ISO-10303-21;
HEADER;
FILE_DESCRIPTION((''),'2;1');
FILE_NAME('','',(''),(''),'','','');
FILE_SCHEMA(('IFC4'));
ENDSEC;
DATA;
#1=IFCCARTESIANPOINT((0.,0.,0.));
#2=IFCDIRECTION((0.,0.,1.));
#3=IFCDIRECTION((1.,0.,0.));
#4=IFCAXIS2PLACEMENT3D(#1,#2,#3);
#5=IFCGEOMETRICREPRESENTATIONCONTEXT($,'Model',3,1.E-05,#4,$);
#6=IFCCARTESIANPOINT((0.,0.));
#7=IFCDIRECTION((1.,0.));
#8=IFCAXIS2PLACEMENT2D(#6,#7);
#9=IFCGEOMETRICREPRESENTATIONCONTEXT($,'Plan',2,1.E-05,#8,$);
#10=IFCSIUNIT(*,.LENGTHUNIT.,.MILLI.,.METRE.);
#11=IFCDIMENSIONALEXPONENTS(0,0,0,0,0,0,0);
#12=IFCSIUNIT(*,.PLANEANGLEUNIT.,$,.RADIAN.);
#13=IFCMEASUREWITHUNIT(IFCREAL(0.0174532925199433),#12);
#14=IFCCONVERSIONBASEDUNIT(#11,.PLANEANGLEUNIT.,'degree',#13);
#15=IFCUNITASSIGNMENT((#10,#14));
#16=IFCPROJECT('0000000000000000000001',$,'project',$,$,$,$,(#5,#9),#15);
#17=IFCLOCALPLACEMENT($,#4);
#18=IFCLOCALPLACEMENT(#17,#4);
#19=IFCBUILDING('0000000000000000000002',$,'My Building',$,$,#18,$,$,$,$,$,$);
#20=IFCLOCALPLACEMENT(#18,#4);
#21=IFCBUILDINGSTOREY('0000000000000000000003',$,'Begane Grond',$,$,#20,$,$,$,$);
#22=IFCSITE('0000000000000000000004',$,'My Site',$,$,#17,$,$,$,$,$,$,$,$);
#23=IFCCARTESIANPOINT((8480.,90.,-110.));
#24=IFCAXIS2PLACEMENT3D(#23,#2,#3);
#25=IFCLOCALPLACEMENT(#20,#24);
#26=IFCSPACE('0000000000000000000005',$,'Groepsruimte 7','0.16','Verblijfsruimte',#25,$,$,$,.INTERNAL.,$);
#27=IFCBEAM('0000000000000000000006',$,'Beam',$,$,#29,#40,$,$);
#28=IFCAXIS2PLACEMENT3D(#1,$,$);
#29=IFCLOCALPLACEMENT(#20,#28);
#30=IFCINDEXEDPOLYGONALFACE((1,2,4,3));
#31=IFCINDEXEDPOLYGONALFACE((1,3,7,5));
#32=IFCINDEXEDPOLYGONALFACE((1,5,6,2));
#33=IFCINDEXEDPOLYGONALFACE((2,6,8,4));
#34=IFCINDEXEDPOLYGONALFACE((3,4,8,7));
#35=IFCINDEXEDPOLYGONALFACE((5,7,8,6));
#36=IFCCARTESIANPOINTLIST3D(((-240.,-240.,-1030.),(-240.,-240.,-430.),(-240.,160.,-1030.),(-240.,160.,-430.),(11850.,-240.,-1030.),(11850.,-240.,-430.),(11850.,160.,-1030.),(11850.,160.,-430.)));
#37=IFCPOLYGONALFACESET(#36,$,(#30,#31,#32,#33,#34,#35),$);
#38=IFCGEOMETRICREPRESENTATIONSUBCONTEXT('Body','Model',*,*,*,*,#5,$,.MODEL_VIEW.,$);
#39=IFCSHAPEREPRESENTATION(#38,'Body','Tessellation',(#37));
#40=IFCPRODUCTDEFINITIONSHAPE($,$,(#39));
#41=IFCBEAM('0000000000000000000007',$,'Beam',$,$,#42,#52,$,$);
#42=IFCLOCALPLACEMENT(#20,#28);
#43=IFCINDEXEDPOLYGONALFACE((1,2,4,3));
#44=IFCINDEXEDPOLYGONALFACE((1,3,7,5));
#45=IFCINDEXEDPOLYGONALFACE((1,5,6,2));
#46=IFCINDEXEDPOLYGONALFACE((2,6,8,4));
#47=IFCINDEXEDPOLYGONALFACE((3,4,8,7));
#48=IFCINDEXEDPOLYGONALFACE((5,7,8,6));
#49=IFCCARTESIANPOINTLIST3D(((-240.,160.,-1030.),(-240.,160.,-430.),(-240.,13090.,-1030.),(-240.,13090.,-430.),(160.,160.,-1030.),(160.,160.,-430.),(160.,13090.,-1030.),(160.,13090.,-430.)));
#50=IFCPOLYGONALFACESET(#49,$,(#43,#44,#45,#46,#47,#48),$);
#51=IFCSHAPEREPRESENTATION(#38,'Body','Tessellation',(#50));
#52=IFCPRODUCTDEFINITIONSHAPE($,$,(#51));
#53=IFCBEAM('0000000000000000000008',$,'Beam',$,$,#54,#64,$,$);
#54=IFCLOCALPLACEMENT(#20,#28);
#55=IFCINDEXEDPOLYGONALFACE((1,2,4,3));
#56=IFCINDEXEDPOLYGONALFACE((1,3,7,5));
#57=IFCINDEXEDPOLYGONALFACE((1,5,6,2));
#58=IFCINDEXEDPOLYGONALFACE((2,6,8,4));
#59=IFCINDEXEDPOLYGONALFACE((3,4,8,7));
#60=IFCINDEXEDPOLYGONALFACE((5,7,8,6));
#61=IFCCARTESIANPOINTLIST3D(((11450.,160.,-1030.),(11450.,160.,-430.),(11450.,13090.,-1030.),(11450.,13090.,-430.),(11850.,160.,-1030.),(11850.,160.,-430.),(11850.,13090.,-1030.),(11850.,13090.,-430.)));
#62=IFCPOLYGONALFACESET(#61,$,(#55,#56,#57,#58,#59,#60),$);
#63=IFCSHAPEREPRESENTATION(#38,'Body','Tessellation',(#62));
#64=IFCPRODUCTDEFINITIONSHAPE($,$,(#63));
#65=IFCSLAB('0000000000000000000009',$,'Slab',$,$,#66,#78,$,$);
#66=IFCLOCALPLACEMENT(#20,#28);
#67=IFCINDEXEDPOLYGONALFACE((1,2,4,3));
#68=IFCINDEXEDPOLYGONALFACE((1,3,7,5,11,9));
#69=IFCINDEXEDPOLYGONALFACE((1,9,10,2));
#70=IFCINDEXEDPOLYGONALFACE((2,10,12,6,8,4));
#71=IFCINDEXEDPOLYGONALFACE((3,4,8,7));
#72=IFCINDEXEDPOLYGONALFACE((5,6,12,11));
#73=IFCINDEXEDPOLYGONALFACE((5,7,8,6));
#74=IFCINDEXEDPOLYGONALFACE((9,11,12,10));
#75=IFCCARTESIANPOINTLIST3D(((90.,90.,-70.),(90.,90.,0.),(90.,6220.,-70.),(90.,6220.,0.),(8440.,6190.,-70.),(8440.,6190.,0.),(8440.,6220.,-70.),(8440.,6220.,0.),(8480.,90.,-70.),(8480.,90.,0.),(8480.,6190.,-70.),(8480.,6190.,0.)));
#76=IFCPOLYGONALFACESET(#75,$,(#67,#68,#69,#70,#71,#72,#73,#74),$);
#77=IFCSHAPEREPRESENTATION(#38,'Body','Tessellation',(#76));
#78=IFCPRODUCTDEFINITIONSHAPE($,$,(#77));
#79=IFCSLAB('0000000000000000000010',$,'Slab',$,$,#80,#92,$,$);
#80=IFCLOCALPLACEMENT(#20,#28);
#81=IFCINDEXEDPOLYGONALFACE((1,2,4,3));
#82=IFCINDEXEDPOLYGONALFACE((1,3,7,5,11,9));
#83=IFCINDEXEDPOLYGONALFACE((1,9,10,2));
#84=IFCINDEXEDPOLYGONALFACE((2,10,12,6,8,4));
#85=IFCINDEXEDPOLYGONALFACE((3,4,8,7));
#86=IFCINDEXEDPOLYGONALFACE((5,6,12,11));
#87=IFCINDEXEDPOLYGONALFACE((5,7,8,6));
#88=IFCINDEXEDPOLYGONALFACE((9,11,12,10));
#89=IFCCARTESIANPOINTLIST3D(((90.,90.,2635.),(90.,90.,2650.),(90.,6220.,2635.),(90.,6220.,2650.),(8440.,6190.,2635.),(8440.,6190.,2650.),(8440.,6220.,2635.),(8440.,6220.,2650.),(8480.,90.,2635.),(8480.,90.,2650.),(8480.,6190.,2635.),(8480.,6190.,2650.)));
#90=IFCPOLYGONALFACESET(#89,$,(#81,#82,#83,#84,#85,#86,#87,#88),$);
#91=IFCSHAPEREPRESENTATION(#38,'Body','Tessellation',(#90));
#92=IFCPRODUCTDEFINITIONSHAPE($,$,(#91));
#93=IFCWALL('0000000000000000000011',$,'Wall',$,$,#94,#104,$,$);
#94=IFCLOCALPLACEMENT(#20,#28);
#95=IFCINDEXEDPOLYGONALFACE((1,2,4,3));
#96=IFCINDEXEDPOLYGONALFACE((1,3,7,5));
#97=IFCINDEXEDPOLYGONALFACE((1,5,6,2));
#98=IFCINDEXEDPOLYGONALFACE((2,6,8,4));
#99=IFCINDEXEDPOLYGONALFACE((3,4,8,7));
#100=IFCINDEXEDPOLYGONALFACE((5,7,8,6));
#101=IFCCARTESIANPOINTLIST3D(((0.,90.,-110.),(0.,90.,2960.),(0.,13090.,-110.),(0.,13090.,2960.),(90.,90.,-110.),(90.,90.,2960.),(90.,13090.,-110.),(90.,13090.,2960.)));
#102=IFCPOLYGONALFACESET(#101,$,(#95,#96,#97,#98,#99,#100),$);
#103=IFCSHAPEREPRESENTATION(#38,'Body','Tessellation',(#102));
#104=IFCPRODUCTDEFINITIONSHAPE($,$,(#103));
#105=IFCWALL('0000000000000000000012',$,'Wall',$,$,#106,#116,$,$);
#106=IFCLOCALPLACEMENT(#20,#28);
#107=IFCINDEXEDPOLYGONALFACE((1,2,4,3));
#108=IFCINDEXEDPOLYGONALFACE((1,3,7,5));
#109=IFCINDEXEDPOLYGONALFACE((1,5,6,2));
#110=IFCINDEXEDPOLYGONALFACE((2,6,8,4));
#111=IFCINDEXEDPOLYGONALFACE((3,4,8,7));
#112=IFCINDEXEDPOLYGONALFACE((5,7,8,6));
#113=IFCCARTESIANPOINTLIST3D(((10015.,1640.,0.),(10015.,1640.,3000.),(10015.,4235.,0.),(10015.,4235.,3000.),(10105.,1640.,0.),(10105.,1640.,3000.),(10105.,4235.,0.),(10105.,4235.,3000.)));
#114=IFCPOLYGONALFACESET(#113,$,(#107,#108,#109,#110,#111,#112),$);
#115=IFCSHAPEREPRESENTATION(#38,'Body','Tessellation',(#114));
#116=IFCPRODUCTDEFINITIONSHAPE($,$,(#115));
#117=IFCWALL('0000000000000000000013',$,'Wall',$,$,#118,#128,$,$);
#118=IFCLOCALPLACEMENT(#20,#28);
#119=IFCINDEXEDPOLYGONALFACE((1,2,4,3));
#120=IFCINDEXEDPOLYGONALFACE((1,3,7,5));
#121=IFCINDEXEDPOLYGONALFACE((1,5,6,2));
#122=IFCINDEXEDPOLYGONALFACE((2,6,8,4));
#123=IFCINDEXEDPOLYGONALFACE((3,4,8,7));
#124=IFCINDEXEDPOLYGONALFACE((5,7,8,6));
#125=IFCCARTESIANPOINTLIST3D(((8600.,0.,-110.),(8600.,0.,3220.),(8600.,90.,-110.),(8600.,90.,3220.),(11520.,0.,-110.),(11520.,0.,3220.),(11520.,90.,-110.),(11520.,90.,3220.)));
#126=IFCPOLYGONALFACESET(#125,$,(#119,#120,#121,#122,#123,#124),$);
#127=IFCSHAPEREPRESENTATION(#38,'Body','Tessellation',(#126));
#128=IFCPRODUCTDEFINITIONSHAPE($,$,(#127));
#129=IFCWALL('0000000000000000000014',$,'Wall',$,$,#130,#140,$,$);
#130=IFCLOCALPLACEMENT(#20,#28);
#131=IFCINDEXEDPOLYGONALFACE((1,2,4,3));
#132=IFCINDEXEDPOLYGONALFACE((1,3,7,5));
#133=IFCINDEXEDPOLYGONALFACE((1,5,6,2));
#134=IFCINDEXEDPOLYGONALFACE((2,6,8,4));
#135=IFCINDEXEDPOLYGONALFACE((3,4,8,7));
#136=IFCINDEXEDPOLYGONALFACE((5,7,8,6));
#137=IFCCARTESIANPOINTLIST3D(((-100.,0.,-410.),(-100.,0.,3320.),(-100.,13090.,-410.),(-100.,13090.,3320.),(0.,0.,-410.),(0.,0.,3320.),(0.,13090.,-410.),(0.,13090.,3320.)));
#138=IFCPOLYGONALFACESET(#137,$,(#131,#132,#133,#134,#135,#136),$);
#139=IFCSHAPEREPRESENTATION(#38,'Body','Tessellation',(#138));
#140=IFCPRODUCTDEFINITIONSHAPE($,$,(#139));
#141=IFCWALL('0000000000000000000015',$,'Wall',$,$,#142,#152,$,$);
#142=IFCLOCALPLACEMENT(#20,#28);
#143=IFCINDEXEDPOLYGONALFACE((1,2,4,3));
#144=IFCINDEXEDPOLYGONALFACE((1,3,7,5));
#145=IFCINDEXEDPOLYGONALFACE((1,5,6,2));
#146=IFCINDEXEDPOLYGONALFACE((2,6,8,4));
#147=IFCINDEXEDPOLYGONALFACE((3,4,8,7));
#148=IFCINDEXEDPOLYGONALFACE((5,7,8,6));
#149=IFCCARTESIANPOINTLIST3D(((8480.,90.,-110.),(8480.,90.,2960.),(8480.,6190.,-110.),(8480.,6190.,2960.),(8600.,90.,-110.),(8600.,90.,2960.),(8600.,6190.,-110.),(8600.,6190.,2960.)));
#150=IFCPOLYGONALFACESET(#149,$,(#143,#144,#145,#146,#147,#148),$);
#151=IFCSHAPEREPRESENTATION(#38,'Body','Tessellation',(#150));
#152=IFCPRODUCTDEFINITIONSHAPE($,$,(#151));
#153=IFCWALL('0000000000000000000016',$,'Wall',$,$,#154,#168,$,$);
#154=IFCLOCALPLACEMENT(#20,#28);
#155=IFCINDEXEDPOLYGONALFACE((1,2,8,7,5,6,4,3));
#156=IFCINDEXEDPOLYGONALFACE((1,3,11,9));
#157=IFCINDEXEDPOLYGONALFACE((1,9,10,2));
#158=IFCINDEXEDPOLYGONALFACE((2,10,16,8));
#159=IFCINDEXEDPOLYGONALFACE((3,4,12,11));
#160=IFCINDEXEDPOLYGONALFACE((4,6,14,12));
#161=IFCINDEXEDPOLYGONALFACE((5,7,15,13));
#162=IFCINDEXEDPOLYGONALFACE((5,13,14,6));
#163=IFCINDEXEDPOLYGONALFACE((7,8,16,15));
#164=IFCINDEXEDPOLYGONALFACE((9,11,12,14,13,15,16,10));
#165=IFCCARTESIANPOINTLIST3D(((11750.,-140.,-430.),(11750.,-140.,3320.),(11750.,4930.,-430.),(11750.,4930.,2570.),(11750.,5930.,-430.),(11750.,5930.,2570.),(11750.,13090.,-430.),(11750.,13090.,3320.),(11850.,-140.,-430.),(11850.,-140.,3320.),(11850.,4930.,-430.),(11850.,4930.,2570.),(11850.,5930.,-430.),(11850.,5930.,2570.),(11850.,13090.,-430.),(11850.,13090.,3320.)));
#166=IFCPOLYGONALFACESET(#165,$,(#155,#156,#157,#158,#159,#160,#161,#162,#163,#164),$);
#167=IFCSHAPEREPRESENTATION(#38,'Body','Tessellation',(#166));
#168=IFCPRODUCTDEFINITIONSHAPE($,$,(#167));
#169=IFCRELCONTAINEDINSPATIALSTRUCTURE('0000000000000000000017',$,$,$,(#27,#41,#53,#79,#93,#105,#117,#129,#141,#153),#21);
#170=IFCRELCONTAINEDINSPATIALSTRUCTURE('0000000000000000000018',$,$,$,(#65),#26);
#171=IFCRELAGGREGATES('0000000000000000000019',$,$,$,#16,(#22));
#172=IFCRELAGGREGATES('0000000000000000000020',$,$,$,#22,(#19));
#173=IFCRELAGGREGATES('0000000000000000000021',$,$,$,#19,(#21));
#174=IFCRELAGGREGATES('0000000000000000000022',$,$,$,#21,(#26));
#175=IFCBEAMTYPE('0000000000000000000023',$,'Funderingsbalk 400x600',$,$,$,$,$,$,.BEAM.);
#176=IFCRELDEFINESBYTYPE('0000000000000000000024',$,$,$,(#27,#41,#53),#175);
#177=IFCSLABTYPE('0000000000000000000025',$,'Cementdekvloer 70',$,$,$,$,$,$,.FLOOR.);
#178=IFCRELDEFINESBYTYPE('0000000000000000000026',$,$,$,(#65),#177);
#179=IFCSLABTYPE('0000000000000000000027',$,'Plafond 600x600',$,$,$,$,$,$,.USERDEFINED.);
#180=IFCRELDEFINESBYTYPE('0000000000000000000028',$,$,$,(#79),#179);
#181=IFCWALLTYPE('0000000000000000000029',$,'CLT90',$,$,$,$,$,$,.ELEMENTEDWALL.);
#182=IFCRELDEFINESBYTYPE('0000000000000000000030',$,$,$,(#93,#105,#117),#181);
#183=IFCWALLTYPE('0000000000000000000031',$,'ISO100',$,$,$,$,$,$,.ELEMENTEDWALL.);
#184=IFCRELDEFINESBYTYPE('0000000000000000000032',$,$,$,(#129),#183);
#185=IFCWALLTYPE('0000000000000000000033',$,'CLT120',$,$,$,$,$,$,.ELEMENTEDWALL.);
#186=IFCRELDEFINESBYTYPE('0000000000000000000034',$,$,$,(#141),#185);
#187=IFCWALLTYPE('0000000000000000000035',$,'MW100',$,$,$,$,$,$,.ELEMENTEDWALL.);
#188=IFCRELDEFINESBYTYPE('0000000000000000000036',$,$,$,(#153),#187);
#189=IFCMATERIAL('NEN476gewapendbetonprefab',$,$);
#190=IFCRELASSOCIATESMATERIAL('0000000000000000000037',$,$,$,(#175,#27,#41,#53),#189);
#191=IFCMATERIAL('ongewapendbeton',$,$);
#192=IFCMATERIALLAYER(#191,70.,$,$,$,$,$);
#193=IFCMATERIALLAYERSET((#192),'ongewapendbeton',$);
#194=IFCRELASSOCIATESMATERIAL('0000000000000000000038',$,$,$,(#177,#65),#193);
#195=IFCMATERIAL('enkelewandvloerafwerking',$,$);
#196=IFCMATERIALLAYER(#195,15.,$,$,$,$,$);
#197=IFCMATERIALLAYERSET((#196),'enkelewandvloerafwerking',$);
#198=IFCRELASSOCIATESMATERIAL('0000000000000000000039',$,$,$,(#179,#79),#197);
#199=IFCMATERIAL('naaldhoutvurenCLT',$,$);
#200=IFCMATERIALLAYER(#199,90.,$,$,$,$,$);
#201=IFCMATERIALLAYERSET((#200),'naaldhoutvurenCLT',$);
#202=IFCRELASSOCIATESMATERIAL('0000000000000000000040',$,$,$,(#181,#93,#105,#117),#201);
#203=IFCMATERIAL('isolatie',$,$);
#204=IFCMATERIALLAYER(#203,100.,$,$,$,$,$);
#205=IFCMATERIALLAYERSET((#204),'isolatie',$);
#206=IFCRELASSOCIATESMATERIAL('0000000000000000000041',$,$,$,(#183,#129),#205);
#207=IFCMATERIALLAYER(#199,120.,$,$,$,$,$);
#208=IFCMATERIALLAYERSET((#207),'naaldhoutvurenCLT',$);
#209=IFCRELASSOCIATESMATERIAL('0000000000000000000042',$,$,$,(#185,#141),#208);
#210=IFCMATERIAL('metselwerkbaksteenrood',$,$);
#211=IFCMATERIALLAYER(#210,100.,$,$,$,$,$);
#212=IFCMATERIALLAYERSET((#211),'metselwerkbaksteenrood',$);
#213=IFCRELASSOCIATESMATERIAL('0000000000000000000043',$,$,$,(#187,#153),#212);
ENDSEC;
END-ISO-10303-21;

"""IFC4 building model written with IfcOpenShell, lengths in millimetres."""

from ifc_helpers import new_model, entity, si_unit, converted_unit, frame, origin_with_axes, origin_2d_with_axis, place, context, subcontext, project, spatial, line, indexed_curve, rectangle, outline, extrude, source, transform, mapped, material, layer, layer_set, layer_usage, material_profile, profile_set, profile_usage, type_object, element, save


model = new_model("IFC4")

# Units and contexts
model_context = context("Model", 3, precision=1e-05, world=origin_with_axes())
plan_context = context("Plan", 2, precision=1e-05, world=origin_2d_with_axis())
body_context = subcontext(model_context, "Body", "Model", "MODEL_VIEW")
ifc_project = project(units=[si_unit("LENGTHUNIT", "METRE", prefix="MILLI"), converted_unit("PLANEANGLEUNIT", "degree", entity("IfcReal", 0.0174532925199433), si_unit("PLANEANGLEUNIT", "RADIAN"), dimensions=[0, 0, 0, 0, 0, 0, 0])], contexts=[model_context, plan_context])

# Site, building, storey
site_placement = place(None, origin_with_axes())
site = spatial("IfcSite", under=ifc_project, at=site_placement, Name="My Site")
building_placement = place(site_placement, origin_with_axes())
building = spatial("IfcBuilding", under=site, at=building_placement, Name="My Building")
storey_placement = place(building_placement, origin_with_axes())
storey = spatial("IfcBuildingStorey", under=building, at=storey_placement, Name="Begane Grond")

# Beams
ifc_material_1 = material(Name="NEN476gewapendbetonprefab")
ifc_material_profile_1 = material_profile(ifc_material_1, rectangle(XDim=400.0, YDim=600.0))
ifc_profile_set_1 = profile_set([ifc_material_profile_1], Name="gewapendbetonprefab")
ifc_profile_usage_1 = profile_usage(ifc_profile_set_1, cardinal=5)
beam_type = type_object("IfcBeamType", Name="Funderingsbalk 400x600", PredefinedType="BEAM", material=ifc_profile_set_1)
beam_1_placement = place(storey_placement, frame((-240.0, -40.0, -730.0), z_axis=(1.0, 0.0, 0.0), x_axis=(0.0, 1.0, 0.0)))
element("IfcBeam", 1, at=beam_1_placement, inside=storey, type_object=beam_type, material=ifc_profile_usage_1, Name="Beam", context=body_context, shape_type="SweptSolid", body=[
    extrude(rectangle(XDim=400.0, YDim=600.0), origin_with_axes(), (0.0, 0.0, 1.0), 12090.0),
])
ifc_profile_usage_2 = profile_usage(ifc_profile_set_1, cardinal=5)
beam_2_placement = place(storey_placement, frame((-40.0, 160.0, -730.0), z_axis=(0.0, 1.0, 0.0), x_axis=(-1.0, 0.0, 0.0)))
element("IfcBeam", 2, at=beam_2_placement, inside=storey, type_object=beam_type, material=ifc_profile_usage_2, Name="Beam", context=body_context, shape_type="SweptSolid", body=[
    extrude(rectangle(XDim=400.0, YDim=600.0), origin_with_axes(), (0.0, 0.0, 1.0), 12930.0),
])
ifc_profile_usage_3 = profile_usage(ifc_profile_set_1, cardinal=5)
beam_3_placement = place(storey_placement, frame((11650.0, 160.0, -730.0), z_axis=(0.0, 1.0, 0.0), x_axis=(-1.0, 0.0, 0.0)))
element("IfcBeam", 3, at=beam_3_placement, inside=storey, type_object=beam_type, material=ifc_profile_usage_3, Name="Beam", context=body_context, shape_type="SweptSolid", body=[
    extrude(rectangle(XDim=400.0, YDim=600.0), origin_with_axes(), (0.0, 0.0, 1.0), 12930.0),
])

# Shared definitions
ifc_material_2 = material(Name="isolatie")

# Shared definitions
space_1_placement = place(storey_placement, frame((8480.0, 90.0, -110.0), z_axis=(0.0, 0.0, 1.0), x_axis=(1.0, 0.0, 0.0)))
space_1 = spatial("IfcSpace", under=storey, at=space_1_placement, Name="Groepsruimte 7", Description="0.16", ObjectType="Verblijfsruimte", PredefinedType="INTERNAL")

# Slabs
ifc_material_3 = material(Name="ongewapendbeton")
ifc_layer_1 = layer(ifc_material_3, 70.0)
ifc_layer_set_1 = layer_set([ifc_layer_1], Name="ongewapendbeton")
ifc_layer_usage_1 = layer_usage(ifc_layer_set_1, "AXIS3", "POSITIVE", 0.0)
slab_type_1 = type_object("IfcSlabType", Name="Cementdekvloer 70", PredefinedType="FLOOR", material=ifc_layer_set_1)
slab_1_placement = place(space_1_placement, frame((-8390.0, 0.0, 40.0), z_axis=(0.0, 0.0, 1.0), x_axis=(1.0, 0.0, 0.0)))
element("IfcSlab", 4, at=slab_1_placement, inside=space_1, type_object=slab_type_1, material=ifc_layer_usage_1, Name="Slab", context=body_context, shape_type="SweptSolid", body=[
    extrude(outline(indexed_curve([(0.0, 0.0), (8390.0, 0.0), (8350.0, 6130.0), (0.0, 6130.0), (8350.0, 6100.0), (8390.0, 6100.0)], segments=[line(2, 1), line(1, 4), line(4, 3), line(3, 5), line(5, 6), line(6, 2)], self_intersect=False)), None, (0.0, 0.0, 1.0), 70.0),
])
ifc_material_4 = material(Name="enkelewandvloerafwerking")
ifc_layer_2 = layer(ifc_material_4, 15.0)
ifc_layer_set_2 = layer_set([ifc_layer_2], Name="enkelewandvloerafwerking")
ifc_layer_usage_2 = layer_usage(ifc_layer_set_2, "AXIS3", "POSITIVE", 0.0)
slab_type_2 = type_object("IfcSlabType", Name="Plafond 600x600", PredefinedType="USERDEFINED", material=ifc_layer_set_2)
slab_2_placement = place(storey_placement, frame((90.0, 90.0, 2635.0), z_axis=(0.0, 0.0, 1.0), x_axis=(1.0, 0.0, 0.0)))
element("IfcSlab", 5, at=slab_2_placement, inside=storey, type_object=slab_type_2, material=ifc_layer_usage_2, Name="Slab", context=body_context, shape_type="SweptSolid", body=[
    extrude(outline(indexed_curve([(0.0, 0.0), (8390.0, 0.0), (8350.0, 6130.0), (0.0, 6130.0), (8350.0, 6100.0), (8390.0, 6100.0)], segments=[line(3, 5), line(5, 6), line(6, 2), line(2, 1), line(1, 4), line(4, 3)], self_intersect=False)), None, (0.0, 0.0, 1.0), 15.0),
])

# Walls
ifc_material_5 = material(Name="naaldhoutvurenCLT")
ifc_layer_3 = layer(ifc_material_5, 90.0)
ifc_layer_set_3 = layer_set([ifc_layer_3], Name="naaldhoutvurenCLT")
ifc_layer_usage_3 = layer_usage(ifc_layer_set_3, "AXIS2", "POSITIVE", 0.0)
wall_type_1 = type_object("IfcWallType", Name="CLT90", PredefinedType="ELEMENTEDWALL", material=ifc_layer_set_3)
wall_1_placement = place(storey_placement, frame((90.0, 90.0, -110.0), z_axis=(0.0, 0.0, 1.0), x_axis=(0.0, 1.0, 0.0)))
element("IfcWall", 6, at=wall_1_placement, inside=storey, type_object=wall_type_1, material=ifc_layer_usage_3, Name="Wall", context=body_context, shape_type="SweptSolid", body=[
    extrude(outline(indexed_curve([(0.0, 0.0), (0.0, 90.0), (13000.0, 90.0), (13000.0, 0.0), (0.0, 0.0)], self_intersect=False)), origin_with_axes(), (0.0, 0.0, 1.0), 3070.0),
])
ifc_layer_usage_4 = layer_usage(ifc_layer_set_3, "AXIS2", "POSITIVE", 0.0)
wall_2_placement = place(storey_placement, frame((10015.0, 4235.0, 0.0), z_axis=(0.0, 0.0, 1.0), x_axis=(0.0, -1.0, 0.0)))
element("IfcWall", 7, at=wall_2_placement, inside=storey, type_object=wall_type_1, material=ifc_layer_usage_4, Name="Wall", context=body_context, shape_type="SweptSolid", body=[
    extrude(outline(indexed_curve([(0.0, 0.0), (0.0, 90.0), (2595.0, 90.0), (2595.0, 0.0), (0.0, 0.0)], self_intersect=False)), origin_with_axes(), (0.0, 0.0, 1.0), 3000.0),
])

# Walls
ifc_layer_usage_5 = layer_usage(ifc_layer_set_3, "AXIS2", "POSITIVE", 0.0)
wall_3_placement = place(storey_placement, frame((8600.0, 0.0, -110.0), z_axis=(0.0, 0.0, 1.0), x_axis=(1.0, 0.0, 0.0)))
element("IfcWall", 8, at=wall_3_placement, inside=storey, type_object=wall_type_1, material=ifc_layer_usage_5, Name="Wall", context=body_context, shape_type="SweptSolid", body=[
    extrude(outline(indexed_curve([(0.0, 0.0), (0.0, 90.0), (2920.0, 90.0), (2920.0, 0.0), (0.0, 0.0)], self_intersect=False)), origin_with_axes(), (0.0, 0.0, 1.0), 3330.0),
])
ifc_layer_4 = layer(ifc_material_2, 100.0)
ifc_layer_set_4 = layer_set([ifc_layer_4], Name="isolatie")
ifc_layer_usage_6 = layer_usage(ifc_layer_set_4, "AXIS2", "POSITIVE", 0.0)
wall_type_2 = type_object("IfcWallType", Name="ISO100", PredefinedType="ELEMENTEDWALL", material=ifc_layer_set_4)
wall_4_placement = place(storey_placement, frame((0.0, 0.0, -410.0), z_axis=(0.0, 0.0, 1.0), x_axis=(0.0, 1.0, 0.0)))
element("IfcWall", 9, at=wall_4_placement, inside=storey, type_object=wall_type_2, material=ifc_layer_usage_6, Name="Wall", context=body_context, shape_type="SweptSolid", body=[
    extrude(outline(indexed_curve([(0.0, 0.0), (0.0, 100.0), (13090.0, 100.0), (13090.0, 0.0), (0.0, 0.0)], self_intersect=False)), origin_with_axes(), (0.0, 0.0, 1.0), 3730.0),
])
ifc_layer_5 = layer(ifc_material_5, 120.0)
ifc_layer_set_5 = layer_set([ifc_layer_5], Name="naaldhoutvurenCLT")
ifc_layer_usage_7 = layer_usage(ifc_layer_set_5, "AXIS2", "POSITIVE", 0.0)
wall_type_3 = type_object("IfcWallType", Name="CLT120", PredefinedType="ELEMENTEDWALL", material=ifc_layer_set_5)
wall_5_placement = place(storey_placement, frame((8600.0, 90.0, -110.0), z_axis=(0.0, 0.0, 1.0), x_axis=(0.0, 1.0, 0.0)))
element("IfcWall", 10, at=wall_5_placement, inside=storey, type_object=wall_type_3, material=ifc_layer_usage_7, Name="Wall", context=body_context, shape_type="SweptSolid", body=[
    extrude(outline(indexed_curve([(0.0, 0.0), (0.0, 120.0), (6100.0, 120.0), (6100.0, 0.0), (0.0, 0.0)], self_intersect=False)), origin_with_axes(), (0.0, 0.0, 1.0), 3070.0),
])

# Wall, opening
ifc_material_6 = material(Name="metselwerkbaksteenrood")
ifc_layer_6 = layer(ifc_material_6, 100.0)
ifc_layer_set_6 = layer_set([ifc_layer_6], Name="metselwerkbaksteenrood")
ifc_layer_usage_8 = layer_usage(ifc_layer_set_6, "AXIS2", "POSITIVE", 0.0)
wall_type_4 = type_object("IfcWallType", Name="MW100", PredefinedType="ELEMENTEDWALL", material=ifc_layer_set_6)
wall_6_placement = place(storey_placement, frame((11850.0, -140.0, -430.0), z_axis=(0.0, 0.0, 1.0), x_axis=(0.0, 1.0, 0.0)))
wall_6 = element("IfcWall", 11, at=wall_6_placement, inside=storey, type_object=wall_type_4, material=ifc_layer_usage_8, Name="Wall", context=body_context, shape_type="SweptSolid", body=[
    extrude(outline(indexed_curve([(0.0, 0.0), (0.0, 100.0), (13230.0, 100.0), (13230.0, 0.0), (0.0, 0.0)], self_intersect=False)), origin_with_axes(), (0.0, 0.0, 1.0), 3750.0),
])
shared_shape_1 = source(origin_with_axes(), body_context, "Body", "SweptSolid", [
    extrude(outline(indexed_curve([(0.0, -434.9), (0.0, 2570.1), (1000.0, 2570.1), (1000.0, -434.9)], segments=[line(3, 2), line(2, 1), line(1, 4), line(4, 3)], self_intersect=False)), frame((0.0, -600.0, -0.1), z_axis=(0.0, -1.0, 0.0), x_axis=(1.0, 0.0, 0.0)), (0.0, 0.0, -1.0), 1200.0),
])
opening_1_placement = place(wall_6_placement, frame((5070.0, 210.0, 430.0), z_axis=(0.0, 0.0, 1.0), x_axis=(1.0, 0.0, 0.0)))
element("IfcOpeningElement", 12, at=opening_1_placement, cuts=wall_6, PredefinedType="OPENING", context=body_context, shape_type="MappedRepresentation", body=[
    mapped(shared_shape_1, transform((0.0, 0.0, 0.0), x_axis=(1.0, 0.0, 0.0), y_axis=(0.0, 1.0, 0.0), z_axis=(0.0, 0.0, 1.0), scale=1.0)),
])

save(model, "model.ifc")
